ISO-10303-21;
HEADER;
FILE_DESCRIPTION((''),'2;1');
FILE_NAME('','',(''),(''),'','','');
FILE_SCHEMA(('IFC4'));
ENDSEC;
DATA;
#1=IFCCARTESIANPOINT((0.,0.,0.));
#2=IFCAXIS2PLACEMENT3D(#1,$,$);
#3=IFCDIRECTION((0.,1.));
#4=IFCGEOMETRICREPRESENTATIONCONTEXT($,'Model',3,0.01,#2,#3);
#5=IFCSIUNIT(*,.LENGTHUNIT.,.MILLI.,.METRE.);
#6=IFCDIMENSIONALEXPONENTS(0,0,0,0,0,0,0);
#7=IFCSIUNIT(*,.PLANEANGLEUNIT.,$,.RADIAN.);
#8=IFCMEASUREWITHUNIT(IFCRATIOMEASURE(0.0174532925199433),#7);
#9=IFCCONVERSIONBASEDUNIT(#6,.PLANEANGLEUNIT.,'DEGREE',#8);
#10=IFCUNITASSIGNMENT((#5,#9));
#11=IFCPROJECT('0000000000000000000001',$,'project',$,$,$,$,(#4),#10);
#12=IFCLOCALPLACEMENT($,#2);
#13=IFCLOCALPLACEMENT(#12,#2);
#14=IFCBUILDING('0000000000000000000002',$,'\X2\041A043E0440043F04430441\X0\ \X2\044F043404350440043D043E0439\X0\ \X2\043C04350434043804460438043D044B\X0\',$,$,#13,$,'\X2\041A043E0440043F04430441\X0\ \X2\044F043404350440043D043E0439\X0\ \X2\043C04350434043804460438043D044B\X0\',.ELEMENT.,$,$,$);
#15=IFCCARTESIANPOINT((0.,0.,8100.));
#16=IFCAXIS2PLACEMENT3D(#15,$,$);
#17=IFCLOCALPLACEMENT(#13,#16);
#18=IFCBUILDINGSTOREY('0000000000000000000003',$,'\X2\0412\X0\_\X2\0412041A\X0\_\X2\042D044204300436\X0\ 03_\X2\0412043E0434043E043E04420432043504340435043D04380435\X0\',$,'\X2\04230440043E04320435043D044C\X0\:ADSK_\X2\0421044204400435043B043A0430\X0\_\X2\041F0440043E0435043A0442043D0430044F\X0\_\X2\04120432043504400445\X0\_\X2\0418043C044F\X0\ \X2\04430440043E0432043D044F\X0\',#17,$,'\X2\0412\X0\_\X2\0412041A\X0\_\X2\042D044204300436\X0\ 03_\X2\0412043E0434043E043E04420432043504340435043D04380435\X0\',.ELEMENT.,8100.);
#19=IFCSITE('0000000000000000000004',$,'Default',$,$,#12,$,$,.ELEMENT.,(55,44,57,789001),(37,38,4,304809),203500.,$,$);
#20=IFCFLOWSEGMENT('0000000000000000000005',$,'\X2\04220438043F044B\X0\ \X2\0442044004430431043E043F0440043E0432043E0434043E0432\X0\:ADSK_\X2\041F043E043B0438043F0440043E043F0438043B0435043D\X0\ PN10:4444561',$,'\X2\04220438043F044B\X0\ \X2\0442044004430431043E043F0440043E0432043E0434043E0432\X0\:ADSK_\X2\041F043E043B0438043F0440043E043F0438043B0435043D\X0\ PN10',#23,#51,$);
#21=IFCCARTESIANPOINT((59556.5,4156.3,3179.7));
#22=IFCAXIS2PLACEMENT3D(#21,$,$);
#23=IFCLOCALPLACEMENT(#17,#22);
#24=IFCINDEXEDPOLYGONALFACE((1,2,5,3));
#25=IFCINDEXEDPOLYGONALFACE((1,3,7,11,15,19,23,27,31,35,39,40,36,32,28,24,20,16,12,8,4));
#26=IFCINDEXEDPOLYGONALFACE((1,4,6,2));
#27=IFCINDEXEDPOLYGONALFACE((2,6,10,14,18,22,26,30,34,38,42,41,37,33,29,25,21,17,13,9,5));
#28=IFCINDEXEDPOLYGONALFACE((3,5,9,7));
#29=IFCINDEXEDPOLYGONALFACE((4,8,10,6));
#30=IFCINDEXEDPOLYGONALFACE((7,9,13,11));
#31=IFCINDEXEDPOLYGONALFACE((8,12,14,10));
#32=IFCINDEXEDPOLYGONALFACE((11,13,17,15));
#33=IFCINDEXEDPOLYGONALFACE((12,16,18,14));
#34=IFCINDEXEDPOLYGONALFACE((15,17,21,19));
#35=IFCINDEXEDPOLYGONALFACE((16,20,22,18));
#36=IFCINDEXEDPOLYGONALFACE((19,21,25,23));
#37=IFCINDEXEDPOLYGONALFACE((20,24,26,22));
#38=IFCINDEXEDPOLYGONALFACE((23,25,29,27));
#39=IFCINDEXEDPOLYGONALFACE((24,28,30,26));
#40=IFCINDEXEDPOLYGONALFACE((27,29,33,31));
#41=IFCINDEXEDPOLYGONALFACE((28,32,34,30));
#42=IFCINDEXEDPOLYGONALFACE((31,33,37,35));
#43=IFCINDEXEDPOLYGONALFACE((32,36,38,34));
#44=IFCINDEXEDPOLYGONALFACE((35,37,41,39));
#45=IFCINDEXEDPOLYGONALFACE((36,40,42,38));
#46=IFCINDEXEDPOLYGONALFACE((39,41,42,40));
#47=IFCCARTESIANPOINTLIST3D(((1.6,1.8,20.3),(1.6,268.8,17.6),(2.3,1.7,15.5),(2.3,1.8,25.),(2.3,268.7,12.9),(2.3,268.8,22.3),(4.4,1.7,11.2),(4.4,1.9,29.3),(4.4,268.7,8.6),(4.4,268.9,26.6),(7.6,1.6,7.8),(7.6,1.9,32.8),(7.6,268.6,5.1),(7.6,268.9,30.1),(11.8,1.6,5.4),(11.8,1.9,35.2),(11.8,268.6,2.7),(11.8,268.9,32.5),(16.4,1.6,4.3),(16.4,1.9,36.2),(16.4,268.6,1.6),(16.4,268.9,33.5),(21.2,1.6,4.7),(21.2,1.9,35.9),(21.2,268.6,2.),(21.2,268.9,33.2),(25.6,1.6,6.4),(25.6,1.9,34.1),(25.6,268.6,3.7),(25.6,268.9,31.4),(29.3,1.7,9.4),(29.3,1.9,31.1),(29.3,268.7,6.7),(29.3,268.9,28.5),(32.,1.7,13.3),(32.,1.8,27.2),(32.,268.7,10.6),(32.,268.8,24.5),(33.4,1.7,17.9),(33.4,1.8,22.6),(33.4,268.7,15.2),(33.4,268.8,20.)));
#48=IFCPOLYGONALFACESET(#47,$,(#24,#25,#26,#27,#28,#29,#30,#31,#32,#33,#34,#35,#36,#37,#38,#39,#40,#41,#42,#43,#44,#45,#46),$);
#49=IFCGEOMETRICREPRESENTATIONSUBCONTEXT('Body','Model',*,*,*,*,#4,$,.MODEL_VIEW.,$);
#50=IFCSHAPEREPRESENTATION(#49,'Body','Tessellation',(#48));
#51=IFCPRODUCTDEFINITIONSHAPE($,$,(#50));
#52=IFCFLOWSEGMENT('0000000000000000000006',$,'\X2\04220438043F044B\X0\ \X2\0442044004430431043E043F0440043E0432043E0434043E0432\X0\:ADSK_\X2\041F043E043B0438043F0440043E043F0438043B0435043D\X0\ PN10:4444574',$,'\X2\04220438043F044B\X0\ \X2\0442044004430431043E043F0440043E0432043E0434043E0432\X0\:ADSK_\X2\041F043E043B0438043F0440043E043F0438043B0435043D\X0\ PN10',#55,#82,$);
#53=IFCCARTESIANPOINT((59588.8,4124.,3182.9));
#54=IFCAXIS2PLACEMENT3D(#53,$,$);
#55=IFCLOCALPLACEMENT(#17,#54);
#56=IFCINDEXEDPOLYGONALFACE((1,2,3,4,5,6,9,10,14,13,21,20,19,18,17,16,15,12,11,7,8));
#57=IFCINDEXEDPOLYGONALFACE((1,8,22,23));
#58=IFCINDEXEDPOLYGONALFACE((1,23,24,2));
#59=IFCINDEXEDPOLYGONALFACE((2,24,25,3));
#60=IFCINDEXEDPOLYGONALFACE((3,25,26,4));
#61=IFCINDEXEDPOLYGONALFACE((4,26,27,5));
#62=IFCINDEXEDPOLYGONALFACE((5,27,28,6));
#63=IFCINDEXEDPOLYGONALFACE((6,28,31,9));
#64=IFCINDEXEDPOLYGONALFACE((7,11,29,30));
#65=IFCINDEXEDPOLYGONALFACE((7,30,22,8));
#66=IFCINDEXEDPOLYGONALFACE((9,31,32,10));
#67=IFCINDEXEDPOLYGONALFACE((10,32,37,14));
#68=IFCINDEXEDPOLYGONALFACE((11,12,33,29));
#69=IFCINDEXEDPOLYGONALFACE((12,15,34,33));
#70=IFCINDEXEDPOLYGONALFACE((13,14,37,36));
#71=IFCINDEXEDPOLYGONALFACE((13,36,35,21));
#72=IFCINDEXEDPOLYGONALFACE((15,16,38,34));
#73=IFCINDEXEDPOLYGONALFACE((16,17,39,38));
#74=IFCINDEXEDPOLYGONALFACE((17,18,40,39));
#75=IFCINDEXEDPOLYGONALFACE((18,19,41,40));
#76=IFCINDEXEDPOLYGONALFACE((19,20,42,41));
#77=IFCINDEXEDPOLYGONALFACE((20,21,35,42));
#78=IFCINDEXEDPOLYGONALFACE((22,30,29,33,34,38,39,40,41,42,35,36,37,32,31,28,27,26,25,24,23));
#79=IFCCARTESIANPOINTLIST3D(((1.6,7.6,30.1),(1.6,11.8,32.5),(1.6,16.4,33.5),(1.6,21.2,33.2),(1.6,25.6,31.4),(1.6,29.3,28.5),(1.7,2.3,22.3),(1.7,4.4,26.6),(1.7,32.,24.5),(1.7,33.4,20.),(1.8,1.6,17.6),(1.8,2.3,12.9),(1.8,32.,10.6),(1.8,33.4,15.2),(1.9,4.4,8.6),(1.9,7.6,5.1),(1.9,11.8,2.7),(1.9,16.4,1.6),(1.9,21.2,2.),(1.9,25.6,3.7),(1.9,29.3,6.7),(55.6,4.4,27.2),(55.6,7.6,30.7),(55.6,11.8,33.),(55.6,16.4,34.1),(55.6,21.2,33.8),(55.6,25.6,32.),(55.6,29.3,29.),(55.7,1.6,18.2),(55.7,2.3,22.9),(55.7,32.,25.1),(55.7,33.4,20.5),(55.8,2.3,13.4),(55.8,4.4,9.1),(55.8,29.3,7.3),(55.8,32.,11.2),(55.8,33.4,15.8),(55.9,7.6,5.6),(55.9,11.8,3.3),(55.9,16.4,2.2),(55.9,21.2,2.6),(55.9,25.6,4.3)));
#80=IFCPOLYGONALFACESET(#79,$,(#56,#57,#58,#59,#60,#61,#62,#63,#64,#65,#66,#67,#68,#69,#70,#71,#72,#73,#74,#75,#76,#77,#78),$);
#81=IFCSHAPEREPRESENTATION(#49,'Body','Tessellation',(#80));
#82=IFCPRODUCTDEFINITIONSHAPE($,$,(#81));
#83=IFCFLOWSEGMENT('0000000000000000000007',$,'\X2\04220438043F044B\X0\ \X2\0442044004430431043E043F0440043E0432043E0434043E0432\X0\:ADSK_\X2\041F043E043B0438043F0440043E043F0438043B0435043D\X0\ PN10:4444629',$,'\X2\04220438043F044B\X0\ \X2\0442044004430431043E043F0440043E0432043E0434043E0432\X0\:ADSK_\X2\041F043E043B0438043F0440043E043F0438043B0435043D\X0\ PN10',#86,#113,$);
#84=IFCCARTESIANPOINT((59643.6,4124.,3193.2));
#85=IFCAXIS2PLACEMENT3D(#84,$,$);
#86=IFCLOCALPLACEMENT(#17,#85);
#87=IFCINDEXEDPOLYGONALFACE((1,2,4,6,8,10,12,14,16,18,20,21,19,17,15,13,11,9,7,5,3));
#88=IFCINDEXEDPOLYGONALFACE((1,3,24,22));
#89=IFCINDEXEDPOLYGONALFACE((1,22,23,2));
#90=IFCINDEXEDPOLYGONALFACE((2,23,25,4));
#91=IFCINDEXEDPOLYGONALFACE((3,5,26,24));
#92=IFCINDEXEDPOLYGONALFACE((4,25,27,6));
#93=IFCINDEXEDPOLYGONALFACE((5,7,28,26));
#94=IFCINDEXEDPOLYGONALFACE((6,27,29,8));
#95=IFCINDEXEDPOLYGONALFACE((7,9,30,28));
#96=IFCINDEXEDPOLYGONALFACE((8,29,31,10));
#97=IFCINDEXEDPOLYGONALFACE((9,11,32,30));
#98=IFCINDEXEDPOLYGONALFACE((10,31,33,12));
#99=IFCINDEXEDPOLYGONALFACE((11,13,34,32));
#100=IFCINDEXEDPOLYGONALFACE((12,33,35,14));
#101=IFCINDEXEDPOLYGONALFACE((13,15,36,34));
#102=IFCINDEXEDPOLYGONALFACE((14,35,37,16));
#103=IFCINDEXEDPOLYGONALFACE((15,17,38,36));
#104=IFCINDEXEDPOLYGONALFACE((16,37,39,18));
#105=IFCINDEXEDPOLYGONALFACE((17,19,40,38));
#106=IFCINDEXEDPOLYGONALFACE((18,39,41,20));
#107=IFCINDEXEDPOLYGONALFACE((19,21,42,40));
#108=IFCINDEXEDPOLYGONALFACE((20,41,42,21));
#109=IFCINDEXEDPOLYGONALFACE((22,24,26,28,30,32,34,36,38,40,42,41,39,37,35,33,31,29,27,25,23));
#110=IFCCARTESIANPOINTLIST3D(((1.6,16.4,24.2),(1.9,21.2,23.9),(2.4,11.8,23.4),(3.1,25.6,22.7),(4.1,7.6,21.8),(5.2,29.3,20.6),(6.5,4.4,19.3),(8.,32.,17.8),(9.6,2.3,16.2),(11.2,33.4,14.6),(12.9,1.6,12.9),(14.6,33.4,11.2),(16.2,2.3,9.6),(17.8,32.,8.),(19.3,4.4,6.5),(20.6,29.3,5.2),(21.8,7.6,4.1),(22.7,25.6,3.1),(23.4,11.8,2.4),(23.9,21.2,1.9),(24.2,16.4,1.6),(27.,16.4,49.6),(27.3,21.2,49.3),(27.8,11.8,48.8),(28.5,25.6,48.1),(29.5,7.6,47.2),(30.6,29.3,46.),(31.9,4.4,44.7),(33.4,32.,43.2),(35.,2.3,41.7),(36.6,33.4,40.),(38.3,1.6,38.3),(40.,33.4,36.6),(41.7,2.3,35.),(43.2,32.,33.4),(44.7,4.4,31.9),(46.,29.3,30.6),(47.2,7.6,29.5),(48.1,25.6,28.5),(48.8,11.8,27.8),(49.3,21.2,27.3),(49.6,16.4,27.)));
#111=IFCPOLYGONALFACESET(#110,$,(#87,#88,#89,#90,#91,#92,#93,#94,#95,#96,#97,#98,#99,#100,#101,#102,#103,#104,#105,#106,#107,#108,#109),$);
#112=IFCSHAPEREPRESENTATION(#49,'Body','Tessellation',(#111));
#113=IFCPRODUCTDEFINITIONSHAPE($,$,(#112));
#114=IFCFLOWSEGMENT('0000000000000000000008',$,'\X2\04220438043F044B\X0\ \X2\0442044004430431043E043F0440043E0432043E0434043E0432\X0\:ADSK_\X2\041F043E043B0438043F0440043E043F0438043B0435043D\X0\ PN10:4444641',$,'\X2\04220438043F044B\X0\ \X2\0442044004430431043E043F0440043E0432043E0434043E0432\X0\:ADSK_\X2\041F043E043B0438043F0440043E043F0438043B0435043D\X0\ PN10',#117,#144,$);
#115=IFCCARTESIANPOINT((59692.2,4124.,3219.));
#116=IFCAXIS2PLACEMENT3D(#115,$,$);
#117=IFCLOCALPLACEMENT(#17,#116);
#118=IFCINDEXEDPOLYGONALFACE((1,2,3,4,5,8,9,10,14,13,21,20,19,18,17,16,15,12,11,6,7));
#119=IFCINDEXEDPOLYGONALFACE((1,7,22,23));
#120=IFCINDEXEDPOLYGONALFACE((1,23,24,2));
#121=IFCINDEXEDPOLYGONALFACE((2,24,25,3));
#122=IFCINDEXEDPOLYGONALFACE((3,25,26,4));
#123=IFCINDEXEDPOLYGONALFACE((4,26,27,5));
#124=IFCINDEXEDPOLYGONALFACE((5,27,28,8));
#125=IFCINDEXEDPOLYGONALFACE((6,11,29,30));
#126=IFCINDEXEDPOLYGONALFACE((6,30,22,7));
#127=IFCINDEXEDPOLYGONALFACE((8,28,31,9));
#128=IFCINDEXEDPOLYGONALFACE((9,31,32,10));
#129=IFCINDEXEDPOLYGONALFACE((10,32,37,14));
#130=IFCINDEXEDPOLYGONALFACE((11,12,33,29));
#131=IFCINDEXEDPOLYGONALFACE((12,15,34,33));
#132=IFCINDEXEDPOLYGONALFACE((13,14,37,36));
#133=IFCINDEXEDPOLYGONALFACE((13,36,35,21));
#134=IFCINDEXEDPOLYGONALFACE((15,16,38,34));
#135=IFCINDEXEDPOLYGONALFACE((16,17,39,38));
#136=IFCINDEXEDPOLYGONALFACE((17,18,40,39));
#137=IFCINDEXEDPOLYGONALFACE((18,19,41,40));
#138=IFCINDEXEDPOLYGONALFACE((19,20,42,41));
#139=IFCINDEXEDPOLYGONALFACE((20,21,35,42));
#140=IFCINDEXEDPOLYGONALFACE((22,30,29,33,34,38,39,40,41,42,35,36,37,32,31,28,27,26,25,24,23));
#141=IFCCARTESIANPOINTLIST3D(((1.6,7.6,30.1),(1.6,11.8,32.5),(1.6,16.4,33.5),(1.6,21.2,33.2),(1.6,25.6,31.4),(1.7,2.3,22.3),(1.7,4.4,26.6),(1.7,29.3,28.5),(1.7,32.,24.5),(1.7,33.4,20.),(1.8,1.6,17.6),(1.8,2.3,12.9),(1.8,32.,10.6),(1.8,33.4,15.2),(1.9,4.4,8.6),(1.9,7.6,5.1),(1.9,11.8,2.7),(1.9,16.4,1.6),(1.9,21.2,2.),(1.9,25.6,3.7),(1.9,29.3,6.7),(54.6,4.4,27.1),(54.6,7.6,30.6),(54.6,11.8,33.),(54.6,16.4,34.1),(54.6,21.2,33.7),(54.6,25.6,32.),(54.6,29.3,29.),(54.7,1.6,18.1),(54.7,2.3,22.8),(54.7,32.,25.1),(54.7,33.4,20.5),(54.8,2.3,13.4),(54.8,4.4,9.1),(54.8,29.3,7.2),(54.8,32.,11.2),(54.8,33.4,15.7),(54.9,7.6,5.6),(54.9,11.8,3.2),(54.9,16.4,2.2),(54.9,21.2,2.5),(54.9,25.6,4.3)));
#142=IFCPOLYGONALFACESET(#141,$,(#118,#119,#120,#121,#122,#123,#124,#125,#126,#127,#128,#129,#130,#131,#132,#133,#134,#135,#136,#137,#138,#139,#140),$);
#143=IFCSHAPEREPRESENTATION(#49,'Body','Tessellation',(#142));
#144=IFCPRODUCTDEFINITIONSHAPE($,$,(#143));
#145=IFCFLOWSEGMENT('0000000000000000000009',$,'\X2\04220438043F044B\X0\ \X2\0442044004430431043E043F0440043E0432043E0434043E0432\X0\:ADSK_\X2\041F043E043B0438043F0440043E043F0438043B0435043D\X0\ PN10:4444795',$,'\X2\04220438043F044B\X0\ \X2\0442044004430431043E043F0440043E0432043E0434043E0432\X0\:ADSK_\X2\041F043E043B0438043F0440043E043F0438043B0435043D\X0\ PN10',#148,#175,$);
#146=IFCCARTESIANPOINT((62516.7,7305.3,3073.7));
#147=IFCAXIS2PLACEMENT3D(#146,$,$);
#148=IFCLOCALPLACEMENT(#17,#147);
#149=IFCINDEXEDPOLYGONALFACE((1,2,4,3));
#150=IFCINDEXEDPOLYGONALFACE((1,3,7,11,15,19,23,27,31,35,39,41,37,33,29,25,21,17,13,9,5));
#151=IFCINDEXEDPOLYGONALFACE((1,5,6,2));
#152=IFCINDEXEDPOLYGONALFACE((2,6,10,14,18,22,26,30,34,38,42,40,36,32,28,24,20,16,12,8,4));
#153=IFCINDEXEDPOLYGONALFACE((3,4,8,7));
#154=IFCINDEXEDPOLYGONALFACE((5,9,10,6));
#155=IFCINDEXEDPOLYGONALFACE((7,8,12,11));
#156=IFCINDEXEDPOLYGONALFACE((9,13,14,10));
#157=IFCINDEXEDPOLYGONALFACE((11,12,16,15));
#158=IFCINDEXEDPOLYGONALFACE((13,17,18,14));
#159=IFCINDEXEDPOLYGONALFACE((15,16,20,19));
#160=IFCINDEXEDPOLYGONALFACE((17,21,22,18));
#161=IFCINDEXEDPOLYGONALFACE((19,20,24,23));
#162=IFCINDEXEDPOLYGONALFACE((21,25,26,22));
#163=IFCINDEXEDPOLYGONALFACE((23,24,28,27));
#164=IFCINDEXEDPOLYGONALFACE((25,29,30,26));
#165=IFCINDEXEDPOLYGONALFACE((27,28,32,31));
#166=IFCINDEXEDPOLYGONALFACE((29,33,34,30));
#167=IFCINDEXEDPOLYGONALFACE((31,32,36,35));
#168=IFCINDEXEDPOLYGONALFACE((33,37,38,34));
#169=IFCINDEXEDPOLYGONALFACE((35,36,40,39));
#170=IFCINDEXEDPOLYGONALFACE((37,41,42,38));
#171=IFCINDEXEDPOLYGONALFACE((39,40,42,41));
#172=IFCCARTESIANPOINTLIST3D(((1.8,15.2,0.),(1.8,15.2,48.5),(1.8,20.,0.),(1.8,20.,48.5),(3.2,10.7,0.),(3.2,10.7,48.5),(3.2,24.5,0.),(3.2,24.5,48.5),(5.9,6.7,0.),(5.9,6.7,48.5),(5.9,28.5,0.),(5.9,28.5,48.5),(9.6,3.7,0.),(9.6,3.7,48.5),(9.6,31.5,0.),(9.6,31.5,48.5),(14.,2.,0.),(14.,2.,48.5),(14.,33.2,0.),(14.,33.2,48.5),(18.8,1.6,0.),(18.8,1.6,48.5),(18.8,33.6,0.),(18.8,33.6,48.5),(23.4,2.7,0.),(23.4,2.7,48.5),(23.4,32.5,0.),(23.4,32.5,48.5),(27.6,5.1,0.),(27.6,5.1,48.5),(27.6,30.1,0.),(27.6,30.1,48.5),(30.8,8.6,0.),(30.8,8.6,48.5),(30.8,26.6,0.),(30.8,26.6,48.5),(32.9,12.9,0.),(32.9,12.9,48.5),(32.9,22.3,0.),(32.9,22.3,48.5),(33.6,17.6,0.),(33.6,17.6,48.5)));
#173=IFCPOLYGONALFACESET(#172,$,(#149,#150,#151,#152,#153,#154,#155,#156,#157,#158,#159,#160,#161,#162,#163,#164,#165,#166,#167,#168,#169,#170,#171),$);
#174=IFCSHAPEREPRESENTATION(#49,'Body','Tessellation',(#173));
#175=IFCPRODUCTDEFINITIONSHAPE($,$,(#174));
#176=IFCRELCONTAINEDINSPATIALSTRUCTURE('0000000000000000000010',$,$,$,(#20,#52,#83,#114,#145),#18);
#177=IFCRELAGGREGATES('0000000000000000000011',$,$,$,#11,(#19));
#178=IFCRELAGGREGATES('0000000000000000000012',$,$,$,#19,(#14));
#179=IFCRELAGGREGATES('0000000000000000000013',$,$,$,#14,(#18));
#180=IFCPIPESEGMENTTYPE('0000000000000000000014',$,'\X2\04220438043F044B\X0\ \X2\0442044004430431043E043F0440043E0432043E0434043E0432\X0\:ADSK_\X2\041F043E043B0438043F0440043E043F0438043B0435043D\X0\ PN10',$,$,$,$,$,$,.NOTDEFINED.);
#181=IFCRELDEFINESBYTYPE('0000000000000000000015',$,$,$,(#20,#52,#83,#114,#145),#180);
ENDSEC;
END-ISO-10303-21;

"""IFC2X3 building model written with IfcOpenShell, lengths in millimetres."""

from ifc_helpers import new_model, entity, si_unit, converted_unit, direction, frame, origin, origin_2d_with_axis, place, context, subcontext, project, spatial, circle, extrude, type_object, element, save


model = new_model("IFC2X3")

# Units and contexts
model_context = context("Model", 3, precision=0.01, world=origin(), true_north=direction((0.0, 1.0)))
body_context = subcontext(model_context, "Body", "Model", "MODEL_VIEW")
ifc_project = project(units=[si_unit("LENGTHUNIT", "METRE", prefix="MILLI"), converted_unit("PLANEANGLEUNIT", "DEGREE", entity("IfcRatioMeasure", 0.0174532925199433), si_unit("PLANEANGLEUNIT", "RADIAN"), dimensions=[0, 0, 0, 0, 0, 0, 0])], contexts=[model_context])

# Site, building, storey
site_placement = place(None, origin())
site = spatial("IfcSite", under=ifc_project, at=site_placement, Name="Default", CompositionType="ELEMENT", RefLatitude=(55, 44, 57, 789001), RefLongitude=(37, 38, 4, 304809), RefElevation=203500.0)
building_placement = place(site_placement, origin())
building = spatial("IfcBuilding", under=site, at=building_placement, Name="Корпус ядерной медицины", LongName="Корпус ядерной медицины", CompositionType="ELEMENT")
storey_placement = place(building_placement, frame((0.0, 0.0, 8100.0)))
storey = spatial("IfcBuildingStorey", under=building, at=storey_placement, Name="В_ВК_Этаж 03_Водоотведение", ObjectType="Уровень:ADSK_Стрелка_Проектная_Вверх_Имя уровня", LongName="В_ВК_Этаж 03_Водоотведение", CompositionType="ELEMENT", Elevation=8100.0)

# Flow segments
pipe_segment_type_1 = type_object("IfcPipeSegmentType", Name="Типы трубопроводов:ADSK_Полипропилен PN10", PredefinedType="NOTDEFINED")
flow_segment_1_placement = place(storey_placement, frame((59556.5, 4156.3, 3179.7)))
element("IfcFlowSegment", 1, at=flow_segment_1_placement, inside=storey, type_object=pipe_segment_type_1, Name="Типы трубопроводов:ADSK_Полипропилен PN10:4444561", ObjectType="Типы трубопроводов:ADSK_Полипропилен PN10", context=body_context, shape_type="SweptSolid", body=[
    extrude(circle(Radius=16.0, at=origin_2d_with_axis()), frame((17.6, 1.8, 20.3), z_axis=(0.0, 0.99995, -0.01), x_axis=(-1.0, 0.0, 0.0)), (0.0, 0.0, 1.0), 267.0),
])
flow_segment_2_placement = place(storey_placement, frame((59588.8, 4124.0, 3182.9)))
element("IfcFlowSegment", 2, at=flow_segment_2_placement, inside=storey, type_object=pipe_segment_type_1, Name="Типы трубопроводов:ADSK_Полипропилен PN10:4444574", ObjectType="Типы трубопроводов:ADSK_Полипропилен PN10", context=body_context, shape_type="SweptSolid", body=[
    extrude(circle(Radius=16.0, at=origin_2d_with_axis()), frame((1.8, 17.6, 17.6), z_axis=(0.999945, 0.0, 0.010463), x_axis=(0.0, -1.0, 0.0)), (0.0, 0.0, 1.0), 54.0),
])
flow_segment_3_placement = place(storey_placement, frame((59643.6, 4124.0, 3193.2)))
element("IfcFlowSegment", 3, at=flow_segment_3_placement, inside=storey, type_object=pipe_segment_type_1, Name="Типы трубопроводов:ADSK_Полипропилен PN10:4444629", ObjectType="Типы трубопроводов:ADSK_Полипропилен PN10", context=body_context, shape_type="SweptSolid", body=[
    extrude(circle(Radius=16.0, at=origin_2d_with_axis()), frame((12.9, 17.6, 12.9), z_axis=(0.707107, 0.0, 0.707107), x_axis=(0.0, -1.0, 0.0)), (0.0, 0.0, 1.0), 35.9),
])
flow_segment_4_placement = place(storey_placement, frame((59692.2, 4124.0, 3219.0)))
element("IfcFlowSegment", 4, at=flow_segment_4_placement, inside=storey, type_object=pipe_segment_type_1, Name="Типы трубопроводов:ADSK_Полипропилен PN10:4444641", ObjectType="Типы трубопроводов:ADSK_Полипропилен PN10", context=body_context, shape_type="SweptSolid", body=[
    extrude(circle(Radius=16.0, at=origin_2d_with_axis()), frame((1.8, 17.6, 17.6), z_axis=(0.99995, 0.0, 0.01), x_axis=(0.0, -1.0, 0.0)), (0.0, 0.0, 1.0), 53.0),
])
flow_segment_5_placement = place(storey_placement, frame((62516.7, 7305.3, 3073.7)))
element("IfcFlowSegment", 5, at=flow_segment_5_placement, inside=storey, type_object=pipe_segment_type_1, Name="Типы трубопроводов:ADSK_Полипропилен PN10:4444795", ObjectType="Типы трубопроводов:ADSK_Полипропилен PN10", context=body_context, shape_type="SweptSolid", body=[
    extrude(circle(Radius=16.0, at=origin_2d_with_axis()), frame((17.6, 17.6, 0.0)), (0.0, 0.0, 1.0), 48.5),
])

save(model, "model.ifc")
